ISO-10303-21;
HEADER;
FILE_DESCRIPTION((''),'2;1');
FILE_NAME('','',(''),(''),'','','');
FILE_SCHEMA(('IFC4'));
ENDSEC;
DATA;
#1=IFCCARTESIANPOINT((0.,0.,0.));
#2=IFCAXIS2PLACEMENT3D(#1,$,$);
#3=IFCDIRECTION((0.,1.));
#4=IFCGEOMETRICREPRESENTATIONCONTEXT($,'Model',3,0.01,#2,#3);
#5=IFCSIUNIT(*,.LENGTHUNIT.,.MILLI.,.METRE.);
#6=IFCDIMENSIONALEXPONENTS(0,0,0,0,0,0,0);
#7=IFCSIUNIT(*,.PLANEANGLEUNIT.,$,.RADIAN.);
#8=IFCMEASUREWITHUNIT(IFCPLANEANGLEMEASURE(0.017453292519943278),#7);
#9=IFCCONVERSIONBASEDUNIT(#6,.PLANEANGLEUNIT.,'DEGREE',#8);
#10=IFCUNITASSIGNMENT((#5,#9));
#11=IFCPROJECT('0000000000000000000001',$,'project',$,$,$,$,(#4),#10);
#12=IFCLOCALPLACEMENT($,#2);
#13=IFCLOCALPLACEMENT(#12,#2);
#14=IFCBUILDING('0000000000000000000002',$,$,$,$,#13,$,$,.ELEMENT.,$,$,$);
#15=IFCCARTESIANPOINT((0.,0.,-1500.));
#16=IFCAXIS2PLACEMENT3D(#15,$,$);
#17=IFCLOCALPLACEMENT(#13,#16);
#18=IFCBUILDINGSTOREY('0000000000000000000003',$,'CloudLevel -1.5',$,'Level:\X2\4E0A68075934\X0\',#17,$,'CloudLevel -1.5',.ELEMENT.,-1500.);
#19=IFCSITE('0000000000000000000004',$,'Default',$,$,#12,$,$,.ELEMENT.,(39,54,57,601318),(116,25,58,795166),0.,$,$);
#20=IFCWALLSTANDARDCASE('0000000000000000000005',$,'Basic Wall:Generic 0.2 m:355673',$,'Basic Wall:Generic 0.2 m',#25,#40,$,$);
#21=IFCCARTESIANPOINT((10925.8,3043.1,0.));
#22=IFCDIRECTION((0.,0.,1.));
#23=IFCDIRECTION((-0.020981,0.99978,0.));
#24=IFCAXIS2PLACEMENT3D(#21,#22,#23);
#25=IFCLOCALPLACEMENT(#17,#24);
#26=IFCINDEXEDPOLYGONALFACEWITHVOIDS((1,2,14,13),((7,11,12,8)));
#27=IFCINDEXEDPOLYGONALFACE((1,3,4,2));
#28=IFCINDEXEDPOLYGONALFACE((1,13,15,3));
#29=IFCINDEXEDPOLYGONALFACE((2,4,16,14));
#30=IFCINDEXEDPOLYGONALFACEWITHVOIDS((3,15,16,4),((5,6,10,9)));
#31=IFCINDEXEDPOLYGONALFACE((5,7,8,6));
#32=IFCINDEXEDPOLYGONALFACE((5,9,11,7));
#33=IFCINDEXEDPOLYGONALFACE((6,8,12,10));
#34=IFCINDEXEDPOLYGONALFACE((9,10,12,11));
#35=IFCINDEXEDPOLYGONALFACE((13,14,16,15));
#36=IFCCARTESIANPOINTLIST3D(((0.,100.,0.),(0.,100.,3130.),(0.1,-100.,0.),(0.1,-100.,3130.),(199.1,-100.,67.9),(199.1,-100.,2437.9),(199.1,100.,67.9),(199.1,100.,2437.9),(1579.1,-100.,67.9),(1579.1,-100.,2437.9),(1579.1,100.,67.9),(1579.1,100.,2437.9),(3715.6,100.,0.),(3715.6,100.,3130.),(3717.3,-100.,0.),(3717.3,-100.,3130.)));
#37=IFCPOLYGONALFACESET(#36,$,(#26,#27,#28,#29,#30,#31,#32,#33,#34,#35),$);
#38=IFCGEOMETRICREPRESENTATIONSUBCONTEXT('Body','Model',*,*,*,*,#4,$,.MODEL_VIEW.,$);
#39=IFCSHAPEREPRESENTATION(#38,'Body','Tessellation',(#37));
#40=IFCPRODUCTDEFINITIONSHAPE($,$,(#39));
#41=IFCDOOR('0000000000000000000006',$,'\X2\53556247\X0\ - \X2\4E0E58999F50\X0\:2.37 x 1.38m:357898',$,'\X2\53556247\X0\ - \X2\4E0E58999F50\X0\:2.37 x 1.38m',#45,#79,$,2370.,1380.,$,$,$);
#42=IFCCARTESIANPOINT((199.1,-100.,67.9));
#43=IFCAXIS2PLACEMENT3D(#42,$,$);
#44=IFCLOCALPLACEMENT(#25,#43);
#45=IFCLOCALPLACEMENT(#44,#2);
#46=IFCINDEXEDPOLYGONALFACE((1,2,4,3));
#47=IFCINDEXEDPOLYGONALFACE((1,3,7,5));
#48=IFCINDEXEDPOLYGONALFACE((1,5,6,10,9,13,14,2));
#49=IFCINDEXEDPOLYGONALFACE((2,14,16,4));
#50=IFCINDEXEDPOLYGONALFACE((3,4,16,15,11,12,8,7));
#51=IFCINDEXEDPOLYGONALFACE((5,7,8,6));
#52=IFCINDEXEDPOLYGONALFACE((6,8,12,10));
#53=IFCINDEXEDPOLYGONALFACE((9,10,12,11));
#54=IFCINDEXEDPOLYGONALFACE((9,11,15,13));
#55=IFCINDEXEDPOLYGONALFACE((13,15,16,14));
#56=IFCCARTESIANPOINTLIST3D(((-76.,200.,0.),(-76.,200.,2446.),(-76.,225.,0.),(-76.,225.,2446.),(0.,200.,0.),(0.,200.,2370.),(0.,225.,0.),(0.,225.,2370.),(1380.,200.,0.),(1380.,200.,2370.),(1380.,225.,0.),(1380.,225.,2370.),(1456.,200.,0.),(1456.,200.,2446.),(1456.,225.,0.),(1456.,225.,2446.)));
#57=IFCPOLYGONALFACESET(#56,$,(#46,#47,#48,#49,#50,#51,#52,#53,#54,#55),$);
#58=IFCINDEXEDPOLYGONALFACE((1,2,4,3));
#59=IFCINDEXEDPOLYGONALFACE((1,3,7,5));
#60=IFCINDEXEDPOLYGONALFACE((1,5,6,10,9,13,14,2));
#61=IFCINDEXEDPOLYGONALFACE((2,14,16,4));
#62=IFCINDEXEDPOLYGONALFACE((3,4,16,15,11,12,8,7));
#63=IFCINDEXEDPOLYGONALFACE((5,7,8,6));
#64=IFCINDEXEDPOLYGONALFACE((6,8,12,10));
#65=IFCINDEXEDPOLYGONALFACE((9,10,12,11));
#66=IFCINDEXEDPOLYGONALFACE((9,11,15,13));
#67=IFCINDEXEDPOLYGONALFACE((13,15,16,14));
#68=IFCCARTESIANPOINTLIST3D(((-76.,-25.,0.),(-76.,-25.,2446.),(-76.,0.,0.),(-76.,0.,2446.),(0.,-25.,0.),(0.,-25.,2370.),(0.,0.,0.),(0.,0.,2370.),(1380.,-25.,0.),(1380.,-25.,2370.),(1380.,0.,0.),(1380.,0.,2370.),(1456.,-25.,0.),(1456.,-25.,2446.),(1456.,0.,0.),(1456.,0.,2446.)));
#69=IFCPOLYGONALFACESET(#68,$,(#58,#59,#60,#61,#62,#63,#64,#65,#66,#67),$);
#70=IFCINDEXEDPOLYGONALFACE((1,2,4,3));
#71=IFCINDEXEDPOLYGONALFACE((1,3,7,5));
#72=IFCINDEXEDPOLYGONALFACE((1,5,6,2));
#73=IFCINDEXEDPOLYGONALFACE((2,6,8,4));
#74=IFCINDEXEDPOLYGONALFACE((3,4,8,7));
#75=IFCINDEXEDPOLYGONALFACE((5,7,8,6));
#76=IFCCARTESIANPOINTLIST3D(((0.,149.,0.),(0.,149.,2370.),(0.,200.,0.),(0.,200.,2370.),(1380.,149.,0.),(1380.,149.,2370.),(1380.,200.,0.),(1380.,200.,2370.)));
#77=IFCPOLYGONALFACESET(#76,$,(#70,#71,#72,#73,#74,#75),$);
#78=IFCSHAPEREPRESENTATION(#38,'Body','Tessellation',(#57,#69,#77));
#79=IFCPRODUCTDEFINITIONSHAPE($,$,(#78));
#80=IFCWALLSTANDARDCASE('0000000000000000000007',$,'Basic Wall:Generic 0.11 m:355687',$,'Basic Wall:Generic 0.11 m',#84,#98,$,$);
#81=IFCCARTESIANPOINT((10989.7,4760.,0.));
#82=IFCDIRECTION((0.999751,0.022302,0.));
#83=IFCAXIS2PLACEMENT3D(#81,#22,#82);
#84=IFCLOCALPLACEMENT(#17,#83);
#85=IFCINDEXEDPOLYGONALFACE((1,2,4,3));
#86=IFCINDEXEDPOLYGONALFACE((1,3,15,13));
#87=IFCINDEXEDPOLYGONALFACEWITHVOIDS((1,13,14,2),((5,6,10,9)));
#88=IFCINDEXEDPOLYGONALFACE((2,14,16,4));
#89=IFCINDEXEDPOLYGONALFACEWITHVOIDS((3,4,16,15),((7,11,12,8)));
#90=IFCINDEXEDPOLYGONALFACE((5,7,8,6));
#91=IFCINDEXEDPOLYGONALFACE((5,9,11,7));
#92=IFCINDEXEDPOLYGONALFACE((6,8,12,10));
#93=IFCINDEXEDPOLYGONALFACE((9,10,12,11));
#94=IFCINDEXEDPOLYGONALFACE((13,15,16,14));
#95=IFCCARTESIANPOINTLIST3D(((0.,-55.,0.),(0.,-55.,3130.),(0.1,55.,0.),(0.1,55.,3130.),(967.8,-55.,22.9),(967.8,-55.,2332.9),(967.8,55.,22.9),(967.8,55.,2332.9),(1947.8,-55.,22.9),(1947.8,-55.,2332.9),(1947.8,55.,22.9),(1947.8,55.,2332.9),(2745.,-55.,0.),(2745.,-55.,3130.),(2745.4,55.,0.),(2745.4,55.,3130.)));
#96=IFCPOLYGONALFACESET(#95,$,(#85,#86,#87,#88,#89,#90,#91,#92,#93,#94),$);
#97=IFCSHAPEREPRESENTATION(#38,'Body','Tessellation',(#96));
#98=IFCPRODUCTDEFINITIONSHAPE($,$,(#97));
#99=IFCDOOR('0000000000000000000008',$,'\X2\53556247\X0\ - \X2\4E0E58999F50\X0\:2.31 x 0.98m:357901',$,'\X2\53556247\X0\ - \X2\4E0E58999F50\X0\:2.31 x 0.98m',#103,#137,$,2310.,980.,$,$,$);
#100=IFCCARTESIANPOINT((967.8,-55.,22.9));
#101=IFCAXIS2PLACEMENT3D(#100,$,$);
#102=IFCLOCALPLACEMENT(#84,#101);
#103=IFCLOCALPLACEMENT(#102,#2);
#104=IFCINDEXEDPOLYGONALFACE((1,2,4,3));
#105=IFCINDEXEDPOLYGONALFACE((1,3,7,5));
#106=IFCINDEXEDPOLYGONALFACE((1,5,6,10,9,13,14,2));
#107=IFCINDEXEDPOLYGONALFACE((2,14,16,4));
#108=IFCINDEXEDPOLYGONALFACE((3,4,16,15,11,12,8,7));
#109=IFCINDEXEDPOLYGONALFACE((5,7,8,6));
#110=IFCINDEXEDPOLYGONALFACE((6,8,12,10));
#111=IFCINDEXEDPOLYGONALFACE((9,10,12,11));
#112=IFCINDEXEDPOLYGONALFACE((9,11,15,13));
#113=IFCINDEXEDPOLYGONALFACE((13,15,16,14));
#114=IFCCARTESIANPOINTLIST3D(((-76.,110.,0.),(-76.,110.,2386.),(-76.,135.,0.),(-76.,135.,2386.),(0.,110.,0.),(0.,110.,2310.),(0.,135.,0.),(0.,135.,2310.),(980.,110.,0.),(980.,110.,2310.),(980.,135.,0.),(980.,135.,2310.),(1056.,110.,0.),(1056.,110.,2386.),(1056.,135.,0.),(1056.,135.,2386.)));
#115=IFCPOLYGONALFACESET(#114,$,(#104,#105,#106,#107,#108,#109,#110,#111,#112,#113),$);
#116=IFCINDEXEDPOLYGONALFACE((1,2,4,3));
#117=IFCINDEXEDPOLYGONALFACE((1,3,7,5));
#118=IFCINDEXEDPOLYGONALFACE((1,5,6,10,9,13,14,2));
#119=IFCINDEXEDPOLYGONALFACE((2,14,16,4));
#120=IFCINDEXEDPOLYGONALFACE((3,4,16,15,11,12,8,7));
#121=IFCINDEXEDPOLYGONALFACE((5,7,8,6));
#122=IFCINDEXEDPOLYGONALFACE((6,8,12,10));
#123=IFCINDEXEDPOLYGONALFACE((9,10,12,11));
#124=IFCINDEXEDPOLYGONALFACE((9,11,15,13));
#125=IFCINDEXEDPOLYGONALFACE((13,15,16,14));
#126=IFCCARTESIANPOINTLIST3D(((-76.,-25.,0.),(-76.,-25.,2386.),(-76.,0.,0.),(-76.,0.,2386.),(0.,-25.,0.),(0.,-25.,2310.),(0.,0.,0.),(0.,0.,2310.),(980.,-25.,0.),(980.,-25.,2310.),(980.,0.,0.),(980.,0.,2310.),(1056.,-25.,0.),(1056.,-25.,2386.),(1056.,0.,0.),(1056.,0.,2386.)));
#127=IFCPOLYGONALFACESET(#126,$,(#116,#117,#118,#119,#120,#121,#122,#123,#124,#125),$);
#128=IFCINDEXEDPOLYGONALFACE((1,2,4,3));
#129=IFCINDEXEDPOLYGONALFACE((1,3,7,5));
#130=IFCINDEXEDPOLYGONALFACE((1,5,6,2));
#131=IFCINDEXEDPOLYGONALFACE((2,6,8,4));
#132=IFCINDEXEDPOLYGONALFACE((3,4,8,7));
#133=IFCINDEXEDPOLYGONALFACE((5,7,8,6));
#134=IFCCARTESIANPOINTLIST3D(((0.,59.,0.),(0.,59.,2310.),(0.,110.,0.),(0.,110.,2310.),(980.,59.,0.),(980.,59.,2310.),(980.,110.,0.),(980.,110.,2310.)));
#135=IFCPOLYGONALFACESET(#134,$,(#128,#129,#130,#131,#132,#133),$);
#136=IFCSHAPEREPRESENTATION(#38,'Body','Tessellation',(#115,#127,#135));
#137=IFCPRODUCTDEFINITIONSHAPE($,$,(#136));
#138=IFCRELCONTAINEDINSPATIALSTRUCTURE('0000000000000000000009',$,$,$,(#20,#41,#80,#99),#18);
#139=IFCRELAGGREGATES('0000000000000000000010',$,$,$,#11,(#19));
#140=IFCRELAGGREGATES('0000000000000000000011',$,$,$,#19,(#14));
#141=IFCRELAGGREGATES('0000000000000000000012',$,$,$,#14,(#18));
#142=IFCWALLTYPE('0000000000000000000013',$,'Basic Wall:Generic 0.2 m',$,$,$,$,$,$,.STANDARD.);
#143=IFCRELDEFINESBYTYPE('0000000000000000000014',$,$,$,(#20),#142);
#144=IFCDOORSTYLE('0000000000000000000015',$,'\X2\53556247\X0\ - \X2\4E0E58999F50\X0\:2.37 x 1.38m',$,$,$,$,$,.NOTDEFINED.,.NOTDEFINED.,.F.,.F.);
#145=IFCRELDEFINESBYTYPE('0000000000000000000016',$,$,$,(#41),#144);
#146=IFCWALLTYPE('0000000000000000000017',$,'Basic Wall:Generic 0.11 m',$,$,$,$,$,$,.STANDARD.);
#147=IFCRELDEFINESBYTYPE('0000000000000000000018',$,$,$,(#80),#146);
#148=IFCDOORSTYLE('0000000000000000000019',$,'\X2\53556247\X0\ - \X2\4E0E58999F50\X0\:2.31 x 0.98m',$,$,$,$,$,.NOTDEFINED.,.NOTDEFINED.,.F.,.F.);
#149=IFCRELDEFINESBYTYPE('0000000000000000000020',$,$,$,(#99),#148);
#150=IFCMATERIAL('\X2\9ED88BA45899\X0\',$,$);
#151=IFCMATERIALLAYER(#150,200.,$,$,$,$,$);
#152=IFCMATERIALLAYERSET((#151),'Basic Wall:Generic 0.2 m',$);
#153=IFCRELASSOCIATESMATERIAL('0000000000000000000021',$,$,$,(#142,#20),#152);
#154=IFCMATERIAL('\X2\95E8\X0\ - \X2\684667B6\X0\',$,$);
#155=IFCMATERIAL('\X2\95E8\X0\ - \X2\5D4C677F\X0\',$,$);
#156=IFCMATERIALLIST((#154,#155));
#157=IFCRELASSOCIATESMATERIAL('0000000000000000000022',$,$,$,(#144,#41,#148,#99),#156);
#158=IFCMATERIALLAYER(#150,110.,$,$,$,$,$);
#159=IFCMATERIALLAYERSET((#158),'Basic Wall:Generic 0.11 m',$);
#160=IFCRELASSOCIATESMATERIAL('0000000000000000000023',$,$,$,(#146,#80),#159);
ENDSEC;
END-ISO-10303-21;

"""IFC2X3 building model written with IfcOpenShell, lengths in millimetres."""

from ifc_helpers import new_model, entity, si_unit, converted_unit, direction, frame, frame_2d, origin, origin_2d_with_axis, place, context, subcontext, project, spatial, polyline, rectangle, outline, extrude, source, transform, mapped, material, material_list, layer, layer_set, layer_usage, type_object, type_shapes, element, fill, save


model = new_model("IFC2X3")

# Units and contexts
model_context = context("Model", 3, precision=0.01, world=origin(), true_north=direction((0.0, 1.0)))
body_context = subcontext(model_context, "Body", "Model", "MODEL_VIEW")
ifc_project = project(units=[si_unit("LENGTHUNIT", "METRE", prefix="MILLI"), converted_unit("PLANEANGLEUNIT", "DEGREE", entity("IfcPlaneAngleMeasure", 0.017453292519943278), si_unit("PLANEANGLEUNIT", "RADIAN"), dimensions=[0, 0, 0, 0, 0, 0, 0])], contexts=[model_context])

# Site, building, storey
site_placement = place(None, origin())
site = spatial("IfcSite", under=ifc_project, at=site_placement, Name="Default", CompositionType="ELEMENT", RefLatitude=(39, 54, 57, 601318), RefLongitude=(116, 25, 58, 795166), RefElevation=0.0)
building_placement = place(site_placement, origin())
building = spatial("IfcBuilding", under=site, at=building_placement, CompositionType="ELEMENT")
storey_placement = place(building_placement, frame((0.0, 0.0, -1500.0)))
storey = spatial("IfcBuildingStorey", under=building, at=storey_placement, Name="CloudLevel -1.5", ObjectType="Level:上标头", LongName="CloudLevel -1.5", CompositionType="ELEMENT", Elevation=-1500.0)

# Shared definitions
ifc_material_1 = material(Name="默认墙")

# Walls, openings, doors
ifc_layer_1 = layer(ifc_material_1, 200.0)
ifc_layer_set_1 = layer_set([ifc_layer_1], Name="Basic Wall:Generic 0.2 m")
ifc_layer_usage_1 = layer_usage(ifc_layer_set_1, "AXIS2", "NEGATIVE", 100.0)
wall_type_1 = type_object("IfcWallType", Name="Basic Wall:Generic 0.2 m", PredefinedType="STANDARD", material=ifc_layer_set_1)
wall_1_placement = place(storey_placement, frame((10925.8, 3043.1, 0.0), z_axis=(0.0, 0.0, 1.0), x_axis=(-0.020981, 0.99978, 0.0)))
wall_1 = element("IfcWallStandardCase", 1, at=wall_1_placement, inside=storey, type_object=wall_type_1, material=ifc_layer_usage_1, Name="Basic Wall:Generic 0.2 m:355673", ObjectType="Basic Wall:Generic 0.2 m", context=body_context, shape_type="SweptSolid", body=[
    extrude(outline(polyline([(3717.3, -100.0), (3715.6, 100.0), (0.0, 100.0), (0.1, -100.0), (1660.2, -100.0), (1770.2, -100.0), (3717.3, -100.0)])), origin(), (0.0, 0.0, 1.0), 3130.0),
])
opening_1_placement = place(wall_1_placement, frame((199.1, -100.0, 67.9)))
opening_1 = element("IfcOpeningElement", 2, at=opening_1_placement, cuts=wall_1, ObjectType="Opening", context=body_context, shape_type="SweptSolid", body=[
    extrude(rectangle(XDim=1380.0, YDim=2370.0, at=frame_2d((1185.0, 690.0), x_axis=(0.0, 1.0))), frame((0.0, 0.0, 0.0), z_axis=(0.0, 1.0, 0.0), x_axis=(0.0, 0.0, 1.0)), (0.0, 0.0, 1.0), 200.0),
])
ifc_material_2 = material(Name="门 - 框架")
ifc_material_3 = material(Name="门 - 嵌板")
ifc_material_list_1 = material_list([ifc_material_2, ifc_material_3])
door_style_1 = type_object("IfcDoorStyle", Name="单扇 - 与墙齐:2.37 x 1.38m", ConstructionType="NOTDEFINED", OperationType="NOTDEFINED", ParameterTakesPrecedence=False, Sizeable=False, material=ifc_material_list_1)
shared_shape_1 = source(origin(), body_context, "Body", "SweptSolid", [
    extrude(outline(polyline([(-766.0, -1242.0), (766.0, -1242.0), (766.0, 1204.0), (690.0, 1204.0), (690.0, -1166.0), (-690.0, -1166.0), (-690.0, 1204.0), (-766.0, 1204.0), (-766.0, -1242.0)])), frame((690.0, 200.0, 1204.0), z_axis=(0.0, 1.0, 0.0), x_axis=(1.0, 0.0, 0.0)), (0.0, 0.0, 1.0), 25.0),
    extrude(outline(polyline([(-1242.0, -766.0), (1204.0, -766.0), (1204.0, -690.0), (-1166.0, -690.0), (-1166.0, 690.0), (1204.0, 690.0), (1204.0, 766.0), (-1242.0, 766.0), (-1242.0, -766.0)])), frame((690.0, -25.0, 1204.0), z_axis=(0.0, 1.0, 0.0), x_axis=(0.0, 0.0, -1.0)), (0.0, 0.0, 1.0), 25.0),
    extrude(rectangle(XDim=51.0, YDim=1380.0, at=frame_2d((0.0, 0.0), x_axis=(1.0, 0.0))), frame((690.0, 174.5, 0.0), z_axis=(0.0, 0.0, 1.0), x_axis=(0.0, 1.0, 0.0)), (0.0, 0.0, 1.0), 2370.0),
])
type_shapes(door_style_1, [shared_shape_1])
door_1_placement = place(opening_1_placement, frame((0.0, 0.0, 0.0)))
door_1 = element("IfcDoor", 3, at=door_1_placement, inside=storey, type_object=door_style_1, material=ifc_material_list_1, Name="单扇 - 与墙齐:2.37 x 1.38m:357898", ObjectType="单扇 - 与墙齐:2.37 x 1.38m", OverallHeight=2370.0, OverallWidth=1380.0, context=body_context, shape_type="MappedRepresentation", body=[
    mapped(shared_shape_1, transform((0.0, 0.0, 0.0), scale=1.0)),
])
fill(opening_1, door_1)
ifc_layer_2 = layer(ifc_material_1, 110.0)
ifc_layer_set_2 = layer_set([ifc_layer_2], Name="Basic Wall:Generic 0.11 m")
ifc_layer_usage_2 = layer_usage(ifc_layer_set_2, "AXIS2", "NEGATIVE", 55.0)
wall_type_2 = type_object("IfcWallType", Name="Basic Wall:Generic 0.11 m", PredefinedType="STANDARD", material=ifc_layer_set_2)
wall_2_placement = place(storey_placement, frame((10989.7, 4760.0, 0.0), z_axis=(0.0, 0.0, 1.0), x_axis=(0.999751, 0.022302, 0.0)))
wall_2 = element("IfcWallStandardCase", 4, at=wall_2_placement, inside=storey, type_object=wall_type_2, material=ifc_layer_usage_2, Name="Basic Wall:Generic 0.11 m:355687", ObjectType="Basic Wall:Generic 0.11 m", context=body_context, shape_type="SweptSolid", body=[
    extrude(outline(polyline([(2745.0, -55.0), (2745.4, 55.0), (0.1, 55.0), (0.0, -55.0), (2745.0, -55.0)])), origin(), (0.0, 0.0, 1.0), 3130.0),
])
opening_2_placement = place(wall_2_placement, frame((967.8, -55.0, 22.9)))
opening_2 = element("IfcOpeningElement", 5, at=opening_2_placement, cuts=wall_2, ObjectType="Opening", context=body_context, shape_type="SweptSolid", body=[
    extrude(rectangle(XDim=980.0, YDim=2310.0, at=frame_2d((1155.0, 490.0), x_axis=(0.0, 1.0))), frame((0.0, 0.0, 0.0), z_axis=(0.0, 1.0, 0.0), x_axis=(0.0, 0.0, 1.0)), (0.0, 0.0, 1.0), 110.0),
])
door_style_2 = type_object("IfcDoorStyle", Name="单扇 - 与墙齐:2.31 x 0.98m", ConstructionType="NOTDEFINED", OperationType="NOTDEFINED", ParameterTakesPrecedence=False, Sizeable=False, material=ifc_material_list_1)
shared_shape_2 = source(origin(), body_context, "Body", "SweptSolid", [
    extrude(outline(polyline([(-566.0, -1212.0), (566.0, -1212.0), (566.0, 1174.0), (490.0, 1174.0), (490.0, -1136.0), (-490.0, -1136.0), (-490.0, 1174.0), (-566.0, 1174.0), (-566.0, -1212.0)])), frame((490.0, 110.0, 1174.0), z_axis=(0.0, 1.0, 0.0), x_axis=(1.0, 0.0, 0.0)), (0.0, 0.0, 1.0), 25.0),
    extrude(outline(polyline([(-1212.0, -566.0), (1174.0, -566.0), (1174.0, -490.0), (-1136.0, -490.0), (-1136.0, 490.0), (1174.0, 490.0), (1174.0, 566.0), (-1212.0, 566.0), (-1212.0, -566.0)])), frame((490.0, -25.0, 1174.0), z_axis=(0.0, 1.0, 0.0), x_axis=(0.0, 0.0, -1.0)), (0.0, 0.0, 1.0), 25.0),
    extrude(rectangle(XDim=51.0, YDim=980.0, at=origin_2d_with_axis()), frame((490.0, 84.5, 0.0), z_axis=(0.0, 0.0, 1.0), x_axis=(0.0, 1.0, 0.0)), (0.0, 0.0, 1.0), 2310.0),
])
type_shapes(door_style_2, [shared_shape_2])
door_2_placement = place(opening_2_placement, frame((0.0, 0.0, 0.0)))
door_2 = element("IfcDoor", 6, at=door_2_placement, inside=storey, type_object=door_style_2, material=ifc_material_list_1, Name="单扇 - 与墙齐:2.31 x 0.98m:357901", ObjectType="单扇 - 与墙齐:2.31 x 0.98m", OverallHeight=2310.0, OverallWidth=980.0, context=body_context, shape_type="MappedRepresentation", body=[
    mapped(shared_shape_2, transform((0.0, 0.0, 0.0), scale=1.0)),
])
fill(opening_2, door_2)

save(model, "model.ifc")
